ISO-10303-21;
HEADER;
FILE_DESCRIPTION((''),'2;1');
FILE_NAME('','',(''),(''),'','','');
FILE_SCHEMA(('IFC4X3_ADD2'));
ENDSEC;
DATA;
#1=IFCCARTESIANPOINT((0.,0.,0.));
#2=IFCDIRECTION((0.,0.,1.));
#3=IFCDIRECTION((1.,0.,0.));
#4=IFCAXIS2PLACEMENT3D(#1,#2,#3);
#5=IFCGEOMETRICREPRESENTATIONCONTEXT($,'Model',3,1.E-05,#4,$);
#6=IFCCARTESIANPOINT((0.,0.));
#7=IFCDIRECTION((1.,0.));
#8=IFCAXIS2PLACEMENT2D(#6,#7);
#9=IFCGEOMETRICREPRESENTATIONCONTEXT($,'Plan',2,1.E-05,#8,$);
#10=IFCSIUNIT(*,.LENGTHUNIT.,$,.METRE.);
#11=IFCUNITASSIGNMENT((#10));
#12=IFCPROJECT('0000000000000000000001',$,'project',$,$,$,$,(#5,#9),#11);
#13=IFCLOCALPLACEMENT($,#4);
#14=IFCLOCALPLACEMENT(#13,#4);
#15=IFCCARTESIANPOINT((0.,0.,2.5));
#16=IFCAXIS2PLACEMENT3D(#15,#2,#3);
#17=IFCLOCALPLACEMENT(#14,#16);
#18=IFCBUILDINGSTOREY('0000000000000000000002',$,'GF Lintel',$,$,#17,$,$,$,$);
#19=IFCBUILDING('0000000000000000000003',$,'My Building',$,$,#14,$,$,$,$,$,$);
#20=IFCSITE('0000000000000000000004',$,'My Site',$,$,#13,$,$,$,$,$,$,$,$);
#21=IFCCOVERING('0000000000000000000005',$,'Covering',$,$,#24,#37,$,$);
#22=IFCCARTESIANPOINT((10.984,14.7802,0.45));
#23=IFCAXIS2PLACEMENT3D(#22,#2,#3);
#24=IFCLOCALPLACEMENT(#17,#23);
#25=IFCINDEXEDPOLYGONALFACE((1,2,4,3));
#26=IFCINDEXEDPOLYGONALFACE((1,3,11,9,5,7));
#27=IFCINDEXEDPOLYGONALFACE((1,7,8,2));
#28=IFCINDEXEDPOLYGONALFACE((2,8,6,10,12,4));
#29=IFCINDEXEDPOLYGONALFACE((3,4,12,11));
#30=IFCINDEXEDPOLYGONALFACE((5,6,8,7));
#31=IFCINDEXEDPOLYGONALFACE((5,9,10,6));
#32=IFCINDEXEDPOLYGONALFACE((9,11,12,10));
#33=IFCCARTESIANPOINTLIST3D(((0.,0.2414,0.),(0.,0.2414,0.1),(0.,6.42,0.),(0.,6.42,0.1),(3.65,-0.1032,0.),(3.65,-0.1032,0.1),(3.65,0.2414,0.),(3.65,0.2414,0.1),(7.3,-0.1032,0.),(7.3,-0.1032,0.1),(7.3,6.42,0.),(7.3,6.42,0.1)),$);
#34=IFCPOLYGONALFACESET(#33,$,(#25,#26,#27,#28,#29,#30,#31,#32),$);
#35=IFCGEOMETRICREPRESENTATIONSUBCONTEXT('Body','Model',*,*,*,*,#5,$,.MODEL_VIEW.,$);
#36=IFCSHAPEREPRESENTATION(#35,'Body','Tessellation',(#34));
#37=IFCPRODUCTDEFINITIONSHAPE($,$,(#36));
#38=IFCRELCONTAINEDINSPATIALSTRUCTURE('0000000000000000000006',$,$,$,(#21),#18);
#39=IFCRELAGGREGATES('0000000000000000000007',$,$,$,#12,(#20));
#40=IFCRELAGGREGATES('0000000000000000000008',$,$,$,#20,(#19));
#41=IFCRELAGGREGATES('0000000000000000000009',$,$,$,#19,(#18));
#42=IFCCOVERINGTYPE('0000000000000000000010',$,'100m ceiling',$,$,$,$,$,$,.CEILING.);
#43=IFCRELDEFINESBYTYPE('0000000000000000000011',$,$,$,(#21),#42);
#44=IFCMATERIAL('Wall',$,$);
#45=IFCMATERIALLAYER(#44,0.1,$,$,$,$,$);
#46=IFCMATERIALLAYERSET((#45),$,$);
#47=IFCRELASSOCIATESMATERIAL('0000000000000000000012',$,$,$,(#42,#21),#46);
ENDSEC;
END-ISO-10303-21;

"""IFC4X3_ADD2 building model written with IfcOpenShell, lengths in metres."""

from ifc_helpers import new_model, si_unit, frame, origin_with_axes, origin_2d_with_axis, place, context, subcontext, project, spatial, line, indexed_curve, outline, extrude, material, layer, layer_set, layer_usage, type_object, element, save


model = new_model("IFC4X3_ADD2")

# Units and contexts
model_context = context("Model", 3, precision=1e-05, world=origin_with_axes())
plan_context = context("Plan", 2, precision=1e-05, world=origin_2d_with_axis())
body_context = subcontext(model_context, "Body", "Model", "MODEL_VIEW")
ifc_project = project(units=[si_unit("LENGTHUNIT", "METRE")], contexts=[model_context, plan_context])

# Site, building, storey
site_placement = place(None, origin_with_axes())
site = spatial("IfcSite", under=ifc_project, at=site_placement, Name="My Site")
building_placement = place(site_placement, origin_with_axes())
building = spatial("IfcBuilding", under=site, at=building_placement, Name="My Building")
storey_placement = place(building_placement, frame((0.0, 0.0, 2.5), z_axis=(0.0, 0.0, 1.0), x_axis=(1.0, 0.0, 0.0)))
storey = spatial("IfcBuildingStorey", under=building, at=storey_placement, Name="GF Lintel")

# Covering
ifc_material_1 = material(Name="Wall")
ifc_layer = layer(ifc_material_1, 0.1)
ifc_layer_set = layer_set([ifc_layer])
ifc_layer_usage = layer_usage(ifc_layer_set, "AXIS3", "POSITIVE", 0.0)
covering_type = type_object("IfcCoveringType", Name="100m ceiling", PredefinedType="CEILING", material=ifc_layer_set)
covering_placement = place(storey_placement, frame((10.984, 14.7802, 0.45), z_axis=(0.0, 0.0, 1.0), x_axis=(1.0, 0.0, 0.0)))
element("IfcCovering", 1, at=covering_placement, inside=storey, type_object=covering_type, material=ifc_layer_usage, Name="Covering", context=body_context, shape_type="SweptSolid", body=[
    extrude(outline(indexed_curve([(0.0, 6.42), (0.0, 0.2414), (3.65, 0.2414), (3.65, -0.1032), (7.3, -0.1032), (7.3, 6.42)], segments=[line(3, 2), line(2, 1), line(1, 6), line(6, 5), line(5, 4), line(4, 3)], self_intersect=False)), None, (0.0, 0.0, 1.0), 0.1),
])

save(model, "model.ifc")
